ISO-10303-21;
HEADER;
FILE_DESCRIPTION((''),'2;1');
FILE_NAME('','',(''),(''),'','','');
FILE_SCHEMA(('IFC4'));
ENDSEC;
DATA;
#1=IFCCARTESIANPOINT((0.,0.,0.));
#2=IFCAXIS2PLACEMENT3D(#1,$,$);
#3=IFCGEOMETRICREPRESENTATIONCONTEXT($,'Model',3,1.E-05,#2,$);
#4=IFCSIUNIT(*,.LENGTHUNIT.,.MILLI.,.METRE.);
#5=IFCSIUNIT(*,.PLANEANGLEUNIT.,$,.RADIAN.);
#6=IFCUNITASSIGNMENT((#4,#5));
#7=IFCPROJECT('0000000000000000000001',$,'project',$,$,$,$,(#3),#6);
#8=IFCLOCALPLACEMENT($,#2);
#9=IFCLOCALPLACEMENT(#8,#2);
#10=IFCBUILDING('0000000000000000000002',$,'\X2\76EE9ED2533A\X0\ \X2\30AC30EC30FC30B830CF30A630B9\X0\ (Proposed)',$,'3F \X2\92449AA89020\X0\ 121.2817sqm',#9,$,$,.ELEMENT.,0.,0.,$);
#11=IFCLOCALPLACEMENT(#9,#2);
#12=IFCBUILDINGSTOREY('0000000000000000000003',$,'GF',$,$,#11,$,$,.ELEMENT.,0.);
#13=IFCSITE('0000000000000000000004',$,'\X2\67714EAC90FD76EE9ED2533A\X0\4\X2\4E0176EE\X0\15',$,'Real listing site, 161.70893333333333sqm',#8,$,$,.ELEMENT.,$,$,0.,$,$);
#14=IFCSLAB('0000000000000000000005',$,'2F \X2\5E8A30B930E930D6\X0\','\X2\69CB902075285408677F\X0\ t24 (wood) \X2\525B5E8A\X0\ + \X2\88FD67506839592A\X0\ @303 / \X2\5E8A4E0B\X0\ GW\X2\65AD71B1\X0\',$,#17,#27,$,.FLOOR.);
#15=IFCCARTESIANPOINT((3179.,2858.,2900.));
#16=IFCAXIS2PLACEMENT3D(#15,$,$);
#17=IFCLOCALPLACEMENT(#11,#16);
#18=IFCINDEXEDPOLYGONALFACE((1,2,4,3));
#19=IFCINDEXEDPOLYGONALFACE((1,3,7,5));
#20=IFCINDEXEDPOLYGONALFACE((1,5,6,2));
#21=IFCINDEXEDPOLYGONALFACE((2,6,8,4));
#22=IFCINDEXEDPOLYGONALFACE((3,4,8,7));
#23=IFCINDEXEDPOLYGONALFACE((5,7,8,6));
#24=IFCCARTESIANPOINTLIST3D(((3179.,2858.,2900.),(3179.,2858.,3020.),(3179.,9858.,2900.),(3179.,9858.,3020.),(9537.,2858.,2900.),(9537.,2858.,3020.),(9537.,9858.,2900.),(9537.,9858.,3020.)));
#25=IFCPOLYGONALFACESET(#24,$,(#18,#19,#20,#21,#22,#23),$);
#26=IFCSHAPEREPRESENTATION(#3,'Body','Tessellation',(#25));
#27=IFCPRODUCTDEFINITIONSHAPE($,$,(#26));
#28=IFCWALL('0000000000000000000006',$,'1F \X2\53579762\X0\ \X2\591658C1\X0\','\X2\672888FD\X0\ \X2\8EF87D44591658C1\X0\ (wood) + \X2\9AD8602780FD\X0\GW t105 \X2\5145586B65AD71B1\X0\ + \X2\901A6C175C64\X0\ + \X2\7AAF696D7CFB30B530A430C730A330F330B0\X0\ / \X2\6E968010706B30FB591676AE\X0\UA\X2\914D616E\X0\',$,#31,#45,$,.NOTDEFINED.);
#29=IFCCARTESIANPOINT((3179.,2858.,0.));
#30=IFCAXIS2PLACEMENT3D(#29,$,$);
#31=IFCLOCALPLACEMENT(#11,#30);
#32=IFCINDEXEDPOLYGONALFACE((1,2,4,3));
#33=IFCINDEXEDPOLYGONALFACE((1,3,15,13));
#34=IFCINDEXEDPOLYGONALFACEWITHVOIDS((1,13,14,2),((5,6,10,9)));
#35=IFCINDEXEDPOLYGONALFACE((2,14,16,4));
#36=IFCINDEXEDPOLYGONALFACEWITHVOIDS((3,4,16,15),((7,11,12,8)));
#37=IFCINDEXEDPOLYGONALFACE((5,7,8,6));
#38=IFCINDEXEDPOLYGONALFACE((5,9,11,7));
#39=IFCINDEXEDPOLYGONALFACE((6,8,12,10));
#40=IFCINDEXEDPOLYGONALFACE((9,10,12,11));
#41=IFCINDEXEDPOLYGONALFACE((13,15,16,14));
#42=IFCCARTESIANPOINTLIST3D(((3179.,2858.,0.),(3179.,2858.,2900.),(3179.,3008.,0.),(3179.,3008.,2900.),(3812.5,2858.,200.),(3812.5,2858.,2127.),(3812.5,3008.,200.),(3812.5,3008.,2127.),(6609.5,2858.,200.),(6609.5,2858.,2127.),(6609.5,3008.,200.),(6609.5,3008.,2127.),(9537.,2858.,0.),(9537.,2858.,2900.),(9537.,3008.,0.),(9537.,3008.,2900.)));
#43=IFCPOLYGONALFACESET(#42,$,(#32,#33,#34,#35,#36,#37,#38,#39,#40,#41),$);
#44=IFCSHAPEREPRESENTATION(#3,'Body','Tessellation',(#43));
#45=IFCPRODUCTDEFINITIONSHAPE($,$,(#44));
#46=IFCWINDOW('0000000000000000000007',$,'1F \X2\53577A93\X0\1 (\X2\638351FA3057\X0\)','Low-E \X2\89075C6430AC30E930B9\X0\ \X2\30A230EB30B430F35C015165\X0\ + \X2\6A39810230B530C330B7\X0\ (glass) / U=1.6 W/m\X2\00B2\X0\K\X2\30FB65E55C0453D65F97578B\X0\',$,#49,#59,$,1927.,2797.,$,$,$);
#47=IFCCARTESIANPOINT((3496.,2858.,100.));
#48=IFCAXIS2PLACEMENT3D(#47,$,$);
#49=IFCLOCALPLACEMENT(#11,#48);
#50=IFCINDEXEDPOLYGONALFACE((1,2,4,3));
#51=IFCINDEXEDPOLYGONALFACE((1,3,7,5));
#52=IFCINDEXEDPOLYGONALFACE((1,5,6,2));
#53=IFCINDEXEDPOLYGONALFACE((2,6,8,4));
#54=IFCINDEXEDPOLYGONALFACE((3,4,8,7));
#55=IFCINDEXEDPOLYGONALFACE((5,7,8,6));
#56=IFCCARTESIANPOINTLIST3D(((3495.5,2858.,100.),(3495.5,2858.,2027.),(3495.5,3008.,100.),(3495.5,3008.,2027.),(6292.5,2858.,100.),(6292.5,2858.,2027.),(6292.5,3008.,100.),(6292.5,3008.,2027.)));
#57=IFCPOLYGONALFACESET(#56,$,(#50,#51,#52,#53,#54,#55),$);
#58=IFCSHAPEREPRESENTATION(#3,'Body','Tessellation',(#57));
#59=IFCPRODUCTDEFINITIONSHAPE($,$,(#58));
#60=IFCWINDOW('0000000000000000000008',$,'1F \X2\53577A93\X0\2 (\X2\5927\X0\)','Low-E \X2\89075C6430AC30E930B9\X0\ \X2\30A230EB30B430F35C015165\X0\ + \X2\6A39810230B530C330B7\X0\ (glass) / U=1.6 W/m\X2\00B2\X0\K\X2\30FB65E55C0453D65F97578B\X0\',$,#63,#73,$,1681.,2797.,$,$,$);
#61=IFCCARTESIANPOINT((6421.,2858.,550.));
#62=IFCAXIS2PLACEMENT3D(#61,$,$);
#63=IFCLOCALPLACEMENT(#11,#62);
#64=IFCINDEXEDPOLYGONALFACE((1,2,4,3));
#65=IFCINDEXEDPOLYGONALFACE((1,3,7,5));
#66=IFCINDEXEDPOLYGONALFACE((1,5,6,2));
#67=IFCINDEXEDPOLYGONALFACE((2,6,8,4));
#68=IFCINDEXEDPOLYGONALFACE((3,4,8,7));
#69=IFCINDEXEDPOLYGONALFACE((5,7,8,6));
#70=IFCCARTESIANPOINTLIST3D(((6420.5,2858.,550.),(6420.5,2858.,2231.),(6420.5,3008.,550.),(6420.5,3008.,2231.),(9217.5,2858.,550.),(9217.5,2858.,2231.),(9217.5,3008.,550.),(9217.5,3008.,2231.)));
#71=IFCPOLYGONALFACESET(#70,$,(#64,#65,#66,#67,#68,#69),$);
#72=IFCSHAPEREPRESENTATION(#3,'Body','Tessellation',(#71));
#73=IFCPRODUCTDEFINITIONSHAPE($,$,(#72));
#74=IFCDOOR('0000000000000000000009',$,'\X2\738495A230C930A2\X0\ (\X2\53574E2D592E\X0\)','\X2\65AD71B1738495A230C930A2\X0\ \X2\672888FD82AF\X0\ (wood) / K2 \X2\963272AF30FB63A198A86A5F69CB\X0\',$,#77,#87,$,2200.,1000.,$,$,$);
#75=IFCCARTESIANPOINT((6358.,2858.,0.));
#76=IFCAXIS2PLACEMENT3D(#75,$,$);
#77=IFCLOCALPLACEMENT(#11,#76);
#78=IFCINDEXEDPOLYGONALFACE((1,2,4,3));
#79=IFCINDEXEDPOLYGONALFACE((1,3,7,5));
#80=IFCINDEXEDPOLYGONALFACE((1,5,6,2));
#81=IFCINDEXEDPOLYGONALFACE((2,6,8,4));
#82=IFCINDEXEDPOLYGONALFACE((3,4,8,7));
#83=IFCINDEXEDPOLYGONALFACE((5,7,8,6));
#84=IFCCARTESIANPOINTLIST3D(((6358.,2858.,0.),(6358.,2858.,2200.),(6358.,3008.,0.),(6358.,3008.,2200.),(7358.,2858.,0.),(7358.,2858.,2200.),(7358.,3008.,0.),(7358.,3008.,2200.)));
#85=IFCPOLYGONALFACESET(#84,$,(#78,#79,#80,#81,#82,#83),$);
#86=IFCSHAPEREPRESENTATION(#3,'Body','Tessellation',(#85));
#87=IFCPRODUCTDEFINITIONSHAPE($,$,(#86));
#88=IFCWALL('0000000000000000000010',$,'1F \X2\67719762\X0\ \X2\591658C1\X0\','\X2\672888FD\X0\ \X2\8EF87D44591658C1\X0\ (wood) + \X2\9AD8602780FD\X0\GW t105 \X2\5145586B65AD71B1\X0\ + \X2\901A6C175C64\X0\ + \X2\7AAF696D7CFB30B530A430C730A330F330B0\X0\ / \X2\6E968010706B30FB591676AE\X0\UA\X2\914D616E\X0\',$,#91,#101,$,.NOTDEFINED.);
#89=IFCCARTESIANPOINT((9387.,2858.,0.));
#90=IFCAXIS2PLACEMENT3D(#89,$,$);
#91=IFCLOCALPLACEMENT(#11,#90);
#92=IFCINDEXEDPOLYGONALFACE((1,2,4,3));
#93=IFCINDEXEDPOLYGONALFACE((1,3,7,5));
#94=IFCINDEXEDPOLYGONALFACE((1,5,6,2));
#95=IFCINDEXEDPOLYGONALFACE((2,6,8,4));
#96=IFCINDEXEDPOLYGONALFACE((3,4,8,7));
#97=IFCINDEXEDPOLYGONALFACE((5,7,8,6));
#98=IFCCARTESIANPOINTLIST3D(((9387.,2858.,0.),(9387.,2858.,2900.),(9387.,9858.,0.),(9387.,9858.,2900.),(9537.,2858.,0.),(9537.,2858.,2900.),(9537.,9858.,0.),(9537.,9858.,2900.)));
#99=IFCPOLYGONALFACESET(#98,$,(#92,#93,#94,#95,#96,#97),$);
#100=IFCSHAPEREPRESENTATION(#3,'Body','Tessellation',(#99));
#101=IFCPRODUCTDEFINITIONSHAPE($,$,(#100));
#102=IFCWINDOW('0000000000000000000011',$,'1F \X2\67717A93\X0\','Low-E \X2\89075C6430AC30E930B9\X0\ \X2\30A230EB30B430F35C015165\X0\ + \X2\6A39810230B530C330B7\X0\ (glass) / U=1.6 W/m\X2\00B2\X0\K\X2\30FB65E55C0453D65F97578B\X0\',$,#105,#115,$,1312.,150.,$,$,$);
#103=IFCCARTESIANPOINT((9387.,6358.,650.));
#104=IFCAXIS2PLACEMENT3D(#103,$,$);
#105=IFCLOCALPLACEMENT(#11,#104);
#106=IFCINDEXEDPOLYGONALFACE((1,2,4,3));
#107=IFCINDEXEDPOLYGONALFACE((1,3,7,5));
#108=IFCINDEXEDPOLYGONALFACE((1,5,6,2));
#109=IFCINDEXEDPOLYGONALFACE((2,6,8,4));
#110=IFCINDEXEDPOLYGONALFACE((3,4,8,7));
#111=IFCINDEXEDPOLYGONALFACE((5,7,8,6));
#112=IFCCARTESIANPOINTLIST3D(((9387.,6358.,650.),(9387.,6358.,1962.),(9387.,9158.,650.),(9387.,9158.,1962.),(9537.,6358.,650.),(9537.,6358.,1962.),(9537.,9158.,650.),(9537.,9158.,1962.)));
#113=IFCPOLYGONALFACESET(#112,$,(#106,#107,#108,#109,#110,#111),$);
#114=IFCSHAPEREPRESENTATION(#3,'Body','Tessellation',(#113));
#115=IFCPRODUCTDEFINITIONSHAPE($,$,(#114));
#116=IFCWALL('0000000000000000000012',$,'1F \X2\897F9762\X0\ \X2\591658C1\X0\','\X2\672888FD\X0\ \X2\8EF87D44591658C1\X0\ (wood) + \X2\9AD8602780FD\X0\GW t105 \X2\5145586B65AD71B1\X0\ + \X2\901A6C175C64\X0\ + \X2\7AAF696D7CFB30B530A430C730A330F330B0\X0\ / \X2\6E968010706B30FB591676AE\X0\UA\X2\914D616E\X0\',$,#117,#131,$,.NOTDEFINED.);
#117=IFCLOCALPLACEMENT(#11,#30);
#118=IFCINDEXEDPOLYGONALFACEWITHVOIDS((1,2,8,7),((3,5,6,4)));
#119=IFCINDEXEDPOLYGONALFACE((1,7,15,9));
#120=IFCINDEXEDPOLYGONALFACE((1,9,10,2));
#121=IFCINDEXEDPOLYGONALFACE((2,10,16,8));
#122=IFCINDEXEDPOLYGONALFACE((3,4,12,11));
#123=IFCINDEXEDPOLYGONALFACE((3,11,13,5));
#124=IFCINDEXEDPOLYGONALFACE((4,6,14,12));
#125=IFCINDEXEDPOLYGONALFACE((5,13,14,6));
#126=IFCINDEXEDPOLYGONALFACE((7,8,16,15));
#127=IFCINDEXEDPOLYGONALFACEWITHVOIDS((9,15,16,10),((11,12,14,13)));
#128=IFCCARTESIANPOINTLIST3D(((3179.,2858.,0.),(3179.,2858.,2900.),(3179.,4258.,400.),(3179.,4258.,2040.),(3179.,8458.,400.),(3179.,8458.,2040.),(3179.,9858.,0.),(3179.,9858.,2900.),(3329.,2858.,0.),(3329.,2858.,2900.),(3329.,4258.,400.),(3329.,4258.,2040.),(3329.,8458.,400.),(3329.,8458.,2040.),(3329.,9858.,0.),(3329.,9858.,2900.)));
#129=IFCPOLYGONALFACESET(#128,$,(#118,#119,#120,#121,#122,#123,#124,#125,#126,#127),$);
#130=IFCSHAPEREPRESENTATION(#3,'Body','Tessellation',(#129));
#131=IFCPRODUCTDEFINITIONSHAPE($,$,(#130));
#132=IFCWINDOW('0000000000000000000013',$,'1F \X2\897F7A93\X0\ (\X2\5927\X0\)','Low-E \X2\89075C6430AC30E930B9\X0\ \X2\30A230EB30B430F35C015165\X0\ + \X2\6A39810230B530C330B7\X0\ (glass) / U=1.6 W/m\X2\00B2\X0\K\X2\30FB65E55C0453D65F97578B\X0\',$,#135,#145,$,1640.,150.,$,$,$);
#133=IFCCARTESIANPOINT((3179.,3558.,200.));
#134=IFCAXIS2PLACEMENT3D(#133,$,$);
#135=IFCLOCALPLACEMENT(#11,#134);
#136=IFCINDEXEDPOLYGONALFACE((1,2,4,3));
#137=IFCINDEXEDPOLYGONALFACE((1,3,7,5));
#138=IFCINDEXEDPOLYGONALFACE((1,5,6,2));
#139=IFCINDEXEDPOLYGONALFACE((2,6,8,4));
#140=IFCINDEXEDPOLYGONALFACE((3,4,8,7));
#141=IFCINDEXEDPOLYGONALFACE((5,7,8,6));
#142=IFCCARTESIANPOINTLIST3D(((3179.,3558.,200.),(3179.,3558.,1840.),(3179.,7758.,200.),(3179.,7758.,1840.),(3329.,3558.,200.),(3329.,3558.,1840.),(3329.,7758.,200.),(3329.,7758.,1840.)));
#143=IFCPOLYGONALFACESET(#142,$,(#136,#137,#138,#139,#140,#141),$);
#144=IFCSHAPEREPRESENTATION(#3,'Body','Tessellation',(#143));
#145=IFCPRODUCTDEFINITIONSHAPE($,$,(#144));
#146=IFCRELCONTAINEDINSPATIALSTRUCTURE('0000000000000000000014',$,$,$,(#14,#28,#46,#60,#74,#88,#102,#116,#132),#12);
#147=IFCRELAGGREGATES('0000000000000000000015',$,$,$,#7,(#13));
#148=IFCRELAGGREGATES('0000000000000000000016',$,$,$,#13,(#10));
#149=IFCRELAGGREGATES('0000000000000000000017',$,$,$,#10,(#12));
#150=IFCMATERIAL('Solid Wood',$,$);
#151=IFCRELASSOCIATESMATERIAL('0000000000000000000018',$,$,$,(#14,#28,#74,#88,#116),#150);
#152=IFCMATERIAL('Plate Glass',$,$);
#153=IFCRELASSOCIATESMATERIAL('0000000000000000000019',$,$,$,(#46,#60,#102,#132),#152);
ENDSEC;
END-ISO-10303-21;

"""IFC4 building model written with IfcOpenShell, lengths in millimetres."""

from ifc_helpers import new_model, si_unit, frame, frame_2d, origin, place, context, project, spatial, rectangle, extrude, material, element, fill, save


model = new_model("IFC4")

# Units and contexts
model_context = context("Model", 3, precision=1e-05, world=origin())
ifc_project = project(units=[si_unit("LENGTHUNIT", "METRE", prefix="MILLI"), si_unit("PLANEANGLEUNIT", "RADIAN")], contexts=[model_context])

# Site, building, storey
site_placement = place(None, origin())
site = spatial("IfcSite", under=ifc_project, at=site_placement, Name="東京都目黒区4丁目15", ObjectType="Real listing site, 161.70893333333333sqm", CompositionType="ELEMENT", RefElevation=0.0)
building_placement = place(site_placement, origin())
building = spatial("IfcBuilding", under=site, at=building_placement, Name="目黒区 ガレージハウス (Proposed)", ObjectType="3F 鉄骨造 121.2817sqm", CompositionType="ELEMENT", ElevationOfRefHeight=0.0, ElevationOfTerrain=0.0)
storey_placement = place(building_placement, origin())
storey = spatial("IfcBuildingStorey", under=building, at=storey_placement, Name="GF", CompositionType="ELEMENT", Elevation=0.0)

# Slab
ifc_material_1 = material(Name="Solid Wood")
slab_1_placement = place(storey_placement, frame((3179.0, 2858.0, 2900.0)))
element("IfcSlab", 1, at=slab_1_placement, inside=storey, material=ifc_material_1, Name="2F 床スラブ", Description="構造用合板 t24 (wood) 剛床 + 製材根太 @303 / 床下 GW断熱", PredefinedType="FLOOR", context=model_context, shape_type="SweptSolid", body=[
    extrude(rectangle(XDim=6358.0, YDim=7000.0, at=frame_2d((3179.0, 3500.0))), frame((3179.0, 2858.0, 2900.0)), (0.0, 0.0, 1.0), 120.0),
])

# Wall, openings, windows, door
wall_1_placement = place(storey_placement, frame((3179.0, 2858.0, 0.0)))
wall_1 = element("IfcWall", 2, at=wall_1_placement, inside=storey, material=ifc_material_1, Name="1F 南面 外壁", Description="木製 軸組外壁 (wood) + 高性能GW t105 充填断熱 + 通気層 + 窯業系サイディング / 準耐火・外皮UA配慮", PredefinedType="NOTDEFINED", context=model_context, shape_type="SweptSolid", body=[
    extrude(rectangle(XDim=6358.0, YDim=150.0, at=frame_2d((3179.0, 75.0))), frame((3179.0, 2858.0, 0.0)), (0.0, 0.0, 1.0), 2900.0),
])
opening_1_placement = place(storey_placement, frame((3496.0, 2858.0, 100.0)))
opening_1 = element("IfcOpeningElement", 3, at=opening_1_placement, cuts=wall_1, PredefinedType="NOTDEFINED", context=model_context, shape_type="SweptSolid", body=[
    extrude(rectangle(XDim=2797.0, YDim=150.0, at=frame_2d((1398.0, 75.0))), frame((3496.0, 2858.0, 100.0)), (0.0, 0.0, 1.0), 1927.0),
])
opening_2_placement = place(storey_placement, frame((6421.0, 2858.0, 550.0)))
opening_2 = element("IfcOpeningElement", 4, at=opening_2_placement, cuts=wall_1, PredefinedType="NOTDEFINED", context=model_context, shape_type="SweptSolid", body=[
    extrude(rectangle(XDim=2797.0, YDim=150.0, at=frame_2d((1398.0, 75.0))), frame((6421.0, 2858.0, 550.0)), (0.0, 0.0, 1.0), 1681.0),
])
opening_3_placement = place(storey_placement, frame((6358.0, 2858.0, 0.0)))
opening_3 = element("IfcOpeningElement", 5, at=opening_3_placement, cuts=wall_1, PredefinedType="NOTDEFINED", context=model_context, shape_type="SweptSolid", body=[
    extrude(rectangle(XDim=1000.0, YDim=150.0, at=frame_2d((500.0, 75.0))), frame((6358.0, 2858.0, 0.0)), (0.0, 0.0, 1.0), 2200.0),
])
ifc_material_2 = material(Name="Plate Glass")
window_1_placement = place(storey_placement, frame((3496.0, 2858.0, 100.0)))
window_1 = element("IfcWindow", 6, at=window_1_placement, inside=storey, material=ifc_material_2, Name="1F 南窓1 (掃出し)", Description="Low-E 複層ガラス アルゴン封入 + 樹脂サッシ (glass) / U=1.6 W/m²K・日射取得型", OverallHeight=1927.0, OverallWidth=2797.0, context=model_context, shape_type="SweptSolid", body=[
    extrude(rectangle(XDim=2797.0, YDim=150.0, at=frame_2d((1398.0, 75.0))), frame((3496.0, 2858.0, 100.0)), (0.0, 0.0, 1.0), 1927.0),
])
fill(opening_1, window_1)
window_2_placement = place(storey_placement, frame((6421.0, 2858.0, 550.0)))
window_2 = element("IfcWindow", 7, at=window_2_placement, inside=storey, material=ifc_material_2, Name="1F 南窓2 (大)", Description="Low-E 複層ガラス アルゴン封入 + 樹脂サッシ (glass) / U=1.6 W/m²K・日射取得型", OverallHeight=1681.0, OverallWidth=2797.0, context=model_context, shape_type="SweptSolid", body=[
    extrude(rectangle(XDim=2797.0, YDim=150.0, at=frame_2d((1398.0, 75.0))), frame((6421.0, 2858.0, 550.0)), (0.0, 0.0, 1.0), 1681.0),
])
fill(opening_2, window_2)
door_placement = place(storey_placement, frame((6358.0, 2858.0, 0.0)))
door = element("IfcDoor", 8, at=door_placement, inside=storey, material=ifc_material_1, Name="玄関ドア (南中央)", Description="断熱玄関ドア 木製芯 (wood) / K2 防犯・採風機構", OverallHeight=2200.0, OverallWidth=1000.0, context=model_context, shape_type="SweptSolid", body=[
    extrude(rectangle(XDim=1000.0, YDim=150.0, at=frame_2d((500.0, 75.0))), frame((6358.0, 2858.0, 0.0)), (0.0, 0.0, 1.0), 2200.0),
])
fill(opening_3, door)

# Walls, openings, windows
wall_2_placement = place(storey_placement, frame((9387.0, 2858.0, 0.0)))
wall_2 = element("IfcWall", 9, at=wall_2_placement, inside=storey, material=ifc_material_1, Name="1F 東面 外壁", Description="木製 軸組外壁 (wood) + 高性能GW t105 充填断熱 + 通気層 + 窯業系サイディング / 準耐火・外皮UA配慮", PredefinedType="NOTDEFINED", context=model_context, shape_type="SweptSolid", body=[
    extrude(rectangle(XDim=150.0, YDim=7000.0, at=frame_2d((75.0, 3500.0))), frame((9387.0, 2858.0, 0.0)), (0.0, 0.0, 1.0), 2900.0),
])
opening_4_placement = place(storey_placement, frame((9387.0, 6358.0, 650.0)))
opening_4 = element("IfcOpeningElement", 10, at=opening_4_placement, cuts=wall_2, PredefinedType="NOTDEFINED", context=model_context, shape_type="SweptSolid", body=[
    extrude(rectangle(XDim=150.0, YDim=2800.0, at=frame_2d((75.0, 1400.0))), frame((9387.0, 6358.0, 650.0)), (0.0, 0.0, 1.0), 1312.0),
])
window_3_placement = place(storey_placement, frame((9387.0, 6358.0, 650.0)))
window_3 = element("IfcWindow", 11, at=window_3_placement, inside=storey, material=ifc_material_2, Name="1F 東窓", Description="Low-E 複層ガラス アルゴン封入 + 樹脂サッシ (glass) / U=1.6 W/m²K・日射取得型", OverallHeight=1312.0, OverallWidth=150.0, context=model_context, shape_type="SweptSolid", body=[
    extrude(rectangle(XDim=150.0, YDim=2800.0, at=frame_2d((75.0, 1400.0))), frame((9387.0, 6358.0, 650.0)), (0.0, 0.0, 1.0), 1312.0),
])
fill(opening_4, window_3)
wall_3_placement = place(storey_placement, frame((3179.0, 2858.0, 0.0)))
wall_3 = element("IfcWall", 12, at=wall_3_placement, inside=storey, material=ifc_material_1, Name="1F 西面 外壁", Description="木製 軸組外壁 (wood) + 高性能GW t105 充填断熱 + 通気層 + 窯業系サイディング / 準耐火・外皮UA配慮", PredefinedType="NOTDEFINED", context=model_context, shape_type="SweptSolid", body=[
    extrude(rectangle(XDim=150.0, YDim=7000.0, at=frame_2d((75.0, 3500.0))), frame((3179.0, 2858.0, 0.0)), (0.0, 0.0, 1.0), 2900.0),
])
opening_5_placement = place(storey_placement, frame((3179.0, 3558.0, 200.0)))
opening_5 = element("IfcOpeningElement", 13, at=opening_5_placement, cuts=wall_3, PredefinedType="NOTDEFINED", context=model_context, shape_type="SweptSolid", body=[
    extrude(rectangle(XDim=150.0, YDim=4200.0, at=frame_2d((75.0, 2100.0))), frame((3179.0, 3558.0, 200.0)), (0.0, 0.0, 1.0), 1640.0),
])
window_4_placement = place(storey_placement, frame((3179.0, 3558.0, 200.0)))
window_4 = element("IfcWindow", 14, at=window_4_placement, inside=storey, material=ifc_material_2, Name="1F 西窓 (大)", Description="Low-E 複層ガラス アルゴン封入 + 樹脂サッシ (glass) / U=1.6 W/m²K・日射取得型", OverallHeight=1640.0, OverallWidth=150.0, context=model_context, shape_type="SweptSolid", body=[
    extrude(rectangle(XDim=150.0, YDim=4200.0, at=frame_2d((75.0, 2100.0))), frame((3179.0, 3558.0, 200.0)), (0.0, 0.0, 1.0), 1640.0),
])
fill(opening_5, window_4)

save(model, "model.ifc")
